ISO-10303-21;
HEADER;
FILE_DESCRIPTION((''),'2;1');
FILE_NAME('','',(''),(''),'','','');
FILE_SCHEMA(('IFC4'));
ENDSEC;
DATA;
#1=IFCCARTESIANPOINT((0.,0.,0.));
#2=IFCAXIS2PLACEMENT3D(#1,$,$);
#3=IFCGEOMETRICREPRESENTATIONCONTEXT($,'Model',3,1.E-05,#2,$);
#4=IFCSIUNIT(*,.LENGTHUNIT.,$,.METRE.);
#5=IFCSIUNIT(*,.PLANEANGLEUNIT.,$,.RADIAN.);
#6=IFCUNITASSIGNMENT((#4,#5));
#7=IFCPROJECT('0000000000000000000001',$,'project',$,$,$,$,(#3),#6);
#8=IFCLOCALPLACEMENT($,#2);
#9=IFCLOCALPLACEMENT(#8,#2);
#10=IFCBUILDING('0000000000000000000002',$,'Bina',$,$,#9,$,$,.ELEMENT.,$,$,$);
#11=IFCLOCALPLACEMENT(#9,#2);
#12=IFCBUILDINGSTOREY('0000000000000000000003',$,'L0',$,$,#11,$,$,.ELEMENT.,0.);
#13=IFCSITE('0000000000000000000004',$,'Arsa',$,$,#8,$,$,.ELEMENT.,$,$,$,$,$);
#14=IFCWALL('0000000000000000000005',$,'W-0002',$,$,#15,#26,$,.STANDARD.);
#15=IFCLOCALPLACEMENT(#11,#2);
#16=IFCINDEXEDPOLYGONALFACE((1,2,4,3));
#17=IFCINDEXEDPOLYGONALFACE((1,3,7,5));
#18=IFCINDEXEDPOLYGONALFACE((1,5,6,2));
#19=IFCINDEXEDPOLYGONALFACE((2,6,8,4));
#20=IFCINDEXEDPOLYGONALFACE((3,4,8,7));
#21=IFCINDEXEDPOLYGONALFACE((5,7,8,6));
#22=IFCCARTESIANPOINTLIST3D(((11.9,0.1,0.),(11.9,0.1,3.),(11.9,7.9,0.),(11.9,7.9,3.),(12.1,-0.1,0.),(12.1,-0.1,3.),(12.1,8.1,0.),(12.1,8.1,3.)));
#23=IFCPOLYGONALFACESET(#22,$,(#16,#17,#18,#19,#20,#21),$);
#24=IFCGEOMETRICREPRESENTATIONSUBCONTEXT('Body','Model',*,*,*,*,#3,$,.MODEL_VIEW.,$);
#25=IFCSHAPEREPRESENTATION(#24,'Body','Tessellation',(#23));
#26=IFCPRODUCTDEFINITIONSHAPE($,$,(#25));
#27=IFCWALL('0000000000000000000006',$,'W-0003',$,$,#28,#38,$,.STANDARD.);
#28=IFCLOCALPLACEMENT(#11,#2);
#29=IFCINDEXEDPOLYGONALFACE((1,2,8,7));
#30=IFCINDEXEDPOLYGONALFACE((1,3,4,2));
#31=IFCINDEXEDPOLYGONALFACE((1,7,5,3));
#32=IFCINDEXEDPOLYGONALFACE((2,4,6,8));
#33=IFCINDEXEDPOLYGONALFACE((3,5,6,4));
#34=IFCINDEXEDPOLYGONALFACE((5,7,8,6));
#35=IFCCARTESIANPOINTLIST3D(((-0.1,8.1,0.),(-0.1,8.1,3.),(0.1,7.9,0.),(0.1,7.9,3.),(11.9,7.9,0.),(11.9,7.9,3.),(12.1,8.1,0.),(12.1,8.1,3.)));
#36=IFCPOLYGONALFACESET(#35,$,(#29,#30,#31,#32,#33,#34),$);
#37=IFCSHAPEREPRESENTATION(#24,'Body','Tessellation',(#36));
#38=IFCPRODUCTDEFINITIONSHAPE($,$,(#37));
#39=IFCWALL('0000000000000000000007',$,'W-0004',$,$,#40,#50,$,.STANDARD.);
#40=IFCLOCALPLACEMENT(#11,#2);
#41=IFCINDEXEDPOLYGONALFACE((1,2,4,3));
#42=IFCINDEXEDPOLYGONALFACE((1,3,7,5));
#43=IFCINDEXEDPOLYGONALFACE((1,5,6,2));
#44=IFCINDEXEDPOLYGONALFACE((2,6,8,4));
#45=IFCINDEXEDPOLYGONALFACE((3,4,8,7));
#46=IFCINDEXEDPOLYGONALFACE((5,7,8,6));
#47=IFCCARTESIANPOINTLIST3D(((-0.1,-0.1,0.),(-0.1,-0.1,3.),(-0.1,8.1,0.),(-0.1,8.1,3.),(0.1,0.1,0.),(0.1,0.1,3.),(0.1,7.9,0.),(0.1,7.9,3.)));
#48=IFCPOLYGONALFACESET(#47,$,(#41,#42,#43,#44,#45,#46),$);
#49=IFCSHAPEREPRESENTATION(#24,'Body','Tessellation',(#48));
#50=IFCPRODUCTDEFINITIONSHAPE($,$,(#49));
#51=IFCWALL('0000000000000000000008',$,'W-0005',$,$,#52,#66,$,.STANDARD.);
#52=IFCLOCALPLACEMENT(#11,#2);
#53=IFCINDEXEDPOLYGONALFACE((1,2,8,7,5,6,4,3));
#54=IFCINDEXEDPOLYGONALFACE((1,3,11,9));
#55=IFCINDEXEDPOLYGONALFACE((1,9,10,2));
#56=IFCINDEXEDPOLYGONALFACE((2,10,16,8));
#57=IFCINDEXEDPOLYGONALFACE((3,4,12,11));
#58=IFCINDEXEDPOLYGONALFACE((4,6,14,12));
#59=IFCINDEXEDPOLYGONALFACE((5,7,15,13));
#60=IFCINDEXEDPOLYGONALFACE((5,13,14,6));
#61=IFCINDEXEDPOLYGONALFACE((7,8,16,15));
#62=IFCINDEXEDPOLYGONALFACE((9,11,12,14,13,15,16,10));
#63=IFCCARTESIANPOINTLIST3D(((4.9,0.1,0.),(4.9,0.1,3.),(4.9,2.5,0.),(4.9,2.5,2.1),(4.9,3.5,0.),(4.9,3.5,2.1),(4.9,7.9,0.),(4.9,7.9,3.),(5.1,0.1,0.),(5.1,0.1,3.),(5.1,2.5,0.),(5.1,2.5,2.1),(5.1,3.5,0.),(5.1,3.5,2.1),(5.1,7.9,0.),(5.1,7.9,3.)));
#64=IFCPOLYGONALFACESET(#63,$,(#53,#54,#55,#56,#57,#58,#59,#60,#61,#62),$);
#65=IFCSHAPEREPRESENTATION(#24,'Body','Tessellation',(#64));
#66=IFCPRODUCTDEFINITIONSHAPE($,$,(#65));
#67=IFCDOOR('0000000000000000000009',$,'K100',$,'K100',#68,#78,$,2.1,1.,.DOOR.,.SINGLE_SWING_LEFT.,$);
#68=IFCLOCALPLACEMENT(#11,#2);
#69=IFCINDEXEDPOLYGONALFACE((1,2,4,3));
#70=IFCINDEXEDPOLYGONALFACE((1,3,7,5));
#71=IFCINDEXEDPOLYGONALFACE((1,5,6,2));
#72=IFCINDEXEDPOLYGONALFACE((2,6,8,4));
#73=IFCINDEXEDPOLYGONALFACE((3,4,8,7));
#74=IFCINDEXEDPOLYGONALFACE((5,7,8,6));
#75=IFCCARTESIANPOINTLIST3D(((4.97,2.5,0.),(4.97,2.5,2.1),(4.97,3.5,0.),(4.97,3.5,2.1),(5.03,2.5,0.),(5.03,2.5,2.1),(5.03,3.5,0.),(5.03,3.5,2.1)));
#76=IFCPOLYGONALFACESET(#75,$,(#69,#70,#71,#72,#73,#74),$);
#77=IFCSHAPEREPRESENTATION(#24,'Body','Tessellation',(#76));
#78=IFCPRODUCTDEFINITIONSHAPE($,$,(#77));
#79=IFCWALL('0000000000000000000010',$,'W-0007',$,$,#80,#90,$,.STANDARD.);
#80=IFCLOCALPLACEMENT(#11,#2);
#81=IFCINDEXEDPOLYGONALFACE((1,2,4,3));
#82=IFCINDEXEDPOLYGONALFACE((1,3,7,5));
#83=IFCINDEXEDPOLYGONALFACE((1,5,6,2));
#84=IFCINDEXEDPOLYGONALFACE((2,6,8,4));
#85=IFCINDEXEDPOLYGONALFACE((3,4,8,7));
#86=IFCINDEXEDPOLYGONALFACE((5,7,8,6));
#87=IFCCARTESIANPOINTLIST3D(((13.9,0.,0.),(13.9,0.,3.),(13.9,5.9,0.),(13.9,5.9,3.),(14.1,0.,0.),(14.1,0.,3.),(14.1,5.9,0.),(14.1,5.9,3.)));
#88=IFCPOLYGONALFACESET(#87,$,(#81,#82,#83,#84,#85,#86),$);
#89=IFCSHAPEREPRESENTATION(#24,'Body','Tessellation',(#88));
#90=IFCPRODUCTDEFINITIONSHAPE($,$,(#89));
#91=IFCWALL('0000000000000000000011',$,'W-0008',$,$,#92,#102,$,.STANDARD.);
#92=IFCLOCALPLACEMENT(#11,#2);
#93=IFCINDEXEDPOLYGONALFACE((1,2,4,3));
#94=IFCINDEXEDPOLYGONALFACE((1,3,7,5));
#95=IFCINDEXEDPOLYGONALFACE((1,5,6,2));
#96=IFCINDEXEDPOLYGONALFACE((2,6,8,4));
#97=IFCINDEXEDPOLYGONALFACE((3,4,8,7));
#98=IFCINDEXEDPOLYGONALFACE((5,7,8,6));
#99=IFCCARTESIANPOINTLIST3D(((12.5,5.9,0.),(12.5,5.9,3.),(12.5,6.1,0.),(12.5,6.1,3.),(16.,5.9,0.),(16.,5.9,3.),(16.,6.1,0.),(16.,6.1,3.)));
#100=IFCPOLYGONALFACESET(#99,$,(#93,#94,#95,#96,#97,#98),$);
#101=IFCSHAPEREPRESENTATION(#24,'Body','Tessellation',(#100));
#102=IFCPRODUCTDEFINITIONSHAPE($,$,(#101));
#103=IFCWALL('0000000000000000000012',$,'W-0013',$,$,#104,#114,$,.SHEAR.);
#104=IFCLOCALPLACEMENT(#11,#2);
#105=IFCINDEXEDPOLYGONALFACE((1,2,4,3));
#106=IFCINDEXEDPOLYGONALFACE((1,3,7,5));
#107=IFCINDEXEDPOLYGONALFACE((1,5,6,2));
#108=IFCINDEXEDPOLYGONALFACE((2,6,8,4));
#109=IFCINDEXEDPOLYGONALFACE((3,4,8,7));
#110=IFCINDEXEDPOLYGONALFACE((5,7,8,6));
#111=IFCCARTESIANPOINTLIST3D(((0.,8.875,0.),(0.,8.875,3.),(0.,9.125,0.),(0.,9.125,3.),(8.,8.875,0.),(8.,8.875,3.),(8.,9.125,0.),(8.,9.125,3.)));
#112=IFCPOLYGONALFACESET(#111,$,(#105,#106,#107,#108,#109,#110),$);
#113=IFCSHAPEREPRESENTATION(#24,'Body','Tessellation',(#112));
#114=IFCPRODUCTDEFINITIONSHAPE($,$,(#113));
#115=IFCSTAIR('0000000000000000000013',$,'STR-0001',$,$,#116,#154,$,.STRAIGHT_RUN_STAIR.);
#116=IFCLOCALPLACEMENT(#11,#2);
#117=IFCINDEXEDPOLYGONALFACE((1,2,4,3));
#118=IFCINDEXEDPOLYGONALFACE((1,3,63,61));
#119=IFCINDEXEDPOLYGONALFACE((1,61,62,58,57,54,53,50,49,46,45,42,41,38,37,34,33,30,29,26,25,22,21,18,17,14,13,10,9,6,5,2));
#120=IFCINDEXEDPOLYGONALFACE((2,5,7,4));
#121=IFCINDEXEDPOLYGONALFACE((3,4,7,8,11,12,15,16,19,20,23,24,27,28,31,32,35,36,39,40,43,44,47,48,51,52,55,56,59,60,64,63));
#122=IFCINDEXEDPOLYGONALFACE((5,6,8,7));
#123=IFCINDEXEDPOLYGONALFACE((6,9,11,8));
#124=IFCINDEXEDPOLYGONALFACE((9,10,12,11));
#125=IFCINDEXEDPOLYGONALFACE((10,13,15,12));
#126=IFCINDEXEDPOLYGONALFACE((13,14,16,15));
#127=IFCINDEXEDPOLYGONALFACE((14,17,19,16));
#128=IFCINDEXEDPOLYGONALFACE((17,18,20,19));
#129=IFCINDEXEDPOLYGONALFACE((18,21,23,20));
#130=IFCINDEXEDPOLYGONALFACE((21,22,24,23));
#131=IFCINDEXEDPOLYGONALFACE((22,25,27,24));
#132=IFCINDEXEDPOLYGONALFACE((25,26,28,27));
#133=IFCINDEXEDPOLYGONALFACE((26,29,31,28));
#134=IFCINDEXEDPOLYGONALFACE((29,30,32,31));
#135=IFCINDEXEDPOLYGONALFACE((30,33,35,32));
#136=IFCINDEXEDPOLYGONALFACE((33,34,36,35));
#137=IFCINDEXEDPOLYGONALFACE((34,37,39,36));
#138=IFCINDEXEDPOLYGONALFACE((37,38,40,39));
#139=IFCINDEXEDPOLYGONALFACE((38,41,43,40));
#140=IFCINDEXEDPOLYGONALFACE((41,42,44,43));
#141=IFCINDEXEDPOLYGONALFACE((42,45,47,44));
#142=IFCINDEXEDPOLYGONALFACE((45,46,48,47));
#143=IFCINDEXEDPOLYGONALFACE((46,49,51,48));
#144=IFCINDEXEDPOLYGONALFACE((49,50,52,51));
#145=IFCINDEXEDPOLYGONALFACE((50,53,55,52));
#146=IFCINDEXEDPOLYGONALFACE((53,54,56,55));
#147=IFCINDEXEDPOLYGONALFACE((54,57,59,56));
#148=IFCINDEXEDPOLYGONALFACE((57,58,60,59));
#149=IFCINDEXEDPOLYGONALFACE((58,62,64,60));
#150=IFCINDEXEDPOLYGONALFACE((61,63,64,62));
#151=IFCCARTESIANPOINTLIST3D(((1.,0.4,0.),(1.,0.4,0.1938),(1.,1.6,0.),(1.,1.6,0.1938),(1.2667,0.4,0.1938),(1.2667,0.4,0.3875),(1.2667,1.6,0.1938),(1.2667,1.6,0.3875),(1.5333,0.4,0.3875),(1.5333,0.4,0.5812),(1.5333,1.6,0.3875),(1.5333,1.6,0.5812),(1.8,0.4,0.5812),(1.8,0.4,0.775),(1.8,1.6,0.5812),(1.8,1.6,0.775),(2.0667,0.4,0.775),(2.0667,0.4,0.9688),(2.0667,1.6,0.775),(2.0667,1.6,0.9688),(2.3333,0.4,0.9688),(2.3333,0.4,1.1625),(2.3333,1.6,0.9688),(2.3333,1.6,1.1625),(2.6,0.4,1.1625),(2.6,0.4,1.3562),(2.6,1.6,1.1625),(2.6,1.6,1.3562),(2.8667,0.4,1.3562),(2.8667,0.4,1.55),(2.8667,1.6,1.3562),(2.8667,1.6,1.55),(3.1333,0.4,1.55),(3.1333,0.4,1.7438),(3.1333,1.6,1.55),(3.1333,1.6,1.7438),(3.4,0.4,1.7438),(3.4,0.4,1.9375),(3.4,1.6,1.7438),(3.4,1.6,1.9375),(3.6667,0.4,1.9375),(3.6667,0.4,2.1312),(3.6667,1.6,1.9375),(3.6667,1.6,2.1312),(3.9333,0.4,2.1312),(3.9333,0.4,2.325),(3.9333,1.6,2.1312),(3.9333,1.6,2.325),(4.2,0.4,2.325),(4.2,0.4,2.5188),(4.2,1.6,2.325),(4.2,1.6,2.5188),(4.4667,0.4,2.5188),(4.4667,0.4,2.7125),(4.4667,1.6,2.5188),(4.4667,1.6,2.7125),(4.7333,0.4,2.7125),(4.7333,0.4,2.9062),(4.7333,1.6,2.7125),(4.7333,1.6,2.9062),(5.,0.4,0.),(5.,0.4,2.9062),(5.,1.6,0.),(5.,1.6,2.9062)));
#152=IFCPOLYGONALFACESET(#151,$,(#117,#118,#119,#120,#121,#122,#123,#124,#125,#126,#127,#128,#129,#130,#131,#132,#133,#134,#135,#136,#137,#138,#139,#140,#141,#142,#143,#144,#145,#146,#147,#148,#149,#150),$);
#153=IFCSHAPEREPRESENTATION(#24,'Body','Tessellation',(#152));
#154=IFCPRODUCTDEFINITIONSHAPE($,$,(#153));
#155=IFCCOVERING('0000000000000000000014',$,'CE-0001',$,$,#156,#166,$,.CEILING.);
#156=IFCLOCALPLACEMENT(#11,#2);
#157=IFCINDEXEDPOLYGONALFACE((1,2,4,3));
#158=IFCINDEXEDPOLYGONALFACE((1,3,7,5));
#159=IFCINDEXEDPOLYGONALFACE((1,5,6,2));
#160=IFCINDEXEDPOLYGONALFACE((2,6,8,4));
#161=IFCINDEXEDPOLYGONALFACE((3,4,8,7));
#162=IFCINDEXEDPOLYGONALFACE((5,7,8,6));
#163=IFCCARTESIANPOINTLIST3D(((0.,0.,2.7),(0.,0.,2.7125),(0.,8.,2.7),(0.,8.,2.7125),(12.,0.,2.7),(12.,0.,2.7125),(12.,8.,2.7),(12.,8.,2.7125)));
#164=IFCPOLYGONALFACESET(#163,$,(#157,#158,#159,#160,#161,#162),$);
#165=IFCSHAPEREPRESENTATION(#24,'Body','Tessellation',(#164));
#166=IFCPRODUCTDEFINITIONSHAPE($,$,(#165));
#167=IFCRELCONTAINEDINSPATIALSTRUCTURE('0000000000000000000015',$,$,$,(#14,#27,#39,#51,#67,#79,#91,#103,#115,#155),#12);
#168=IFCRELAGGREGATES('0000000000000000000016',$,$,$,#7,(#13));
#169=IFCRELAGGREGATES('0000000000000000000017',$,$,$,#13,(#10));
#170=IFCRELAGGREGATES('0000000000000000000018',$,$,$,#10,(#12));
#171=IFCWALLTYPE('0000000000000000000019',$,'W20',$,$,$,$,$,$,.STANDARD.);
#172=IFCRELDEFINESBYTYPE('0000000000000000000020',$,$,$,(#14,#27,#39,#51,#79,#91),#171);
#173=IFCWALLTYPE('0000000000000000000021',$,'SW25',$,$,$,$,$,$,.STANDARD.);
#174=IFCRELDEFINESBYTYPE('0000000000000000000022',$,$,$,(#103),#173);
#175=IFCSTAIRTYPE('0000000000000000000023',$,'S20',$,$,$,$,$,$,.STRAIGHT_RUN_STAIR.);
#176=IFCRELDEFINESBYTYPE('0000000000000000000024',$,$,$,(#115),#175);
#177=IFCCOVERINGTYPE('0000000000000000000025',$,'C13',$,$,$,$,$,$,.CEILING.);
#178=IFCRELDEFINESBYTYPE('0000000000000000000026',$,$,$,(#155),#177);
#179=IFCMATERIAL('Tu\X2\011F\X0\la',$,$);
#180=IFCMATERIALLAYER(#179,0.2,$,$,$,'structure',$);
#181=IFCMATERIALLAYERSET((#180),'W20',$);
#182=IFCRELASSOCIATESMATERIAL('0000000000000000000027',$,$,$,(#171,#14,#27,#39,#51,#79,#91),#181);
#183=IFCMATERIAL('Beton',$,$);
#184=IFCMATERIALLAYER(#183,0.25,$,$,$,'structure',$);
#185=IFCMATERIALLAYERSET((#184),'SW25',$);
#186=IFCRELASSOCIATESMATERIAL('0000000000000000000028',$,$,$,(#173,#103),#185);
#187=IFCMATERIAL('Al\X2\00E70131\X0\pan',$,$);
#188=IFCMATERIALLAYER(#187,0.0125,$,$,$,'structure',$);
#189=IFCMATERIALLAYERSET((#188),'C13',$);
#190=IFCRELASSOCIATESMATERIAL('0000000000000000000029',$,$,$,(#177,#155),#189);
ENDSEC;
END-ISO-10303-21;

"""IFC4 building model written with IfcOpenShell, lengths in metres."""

from ifc_helpers import new_model, si_unit, frame, origin, origin_2d, place, context, subcontext, project, spatial, polyline, rectangle, outline, extrude, material, layer, layer_set, layer_usage, type_object, element, fill, save


model = new_model("IFC4")

# Units and contexts
model_context = context("Model", 3, precision=1e-05, world=origin())
body_context = subcontext(model_context, "Body", "Model", "MODEL_VIEW")
ifc_project = project(units=[si_unit("LENGTHUNIT", "METRE"), si_unit("PLANEANGLEUNIT", "RADIAN")], contexts=[model_context])

# Site, building, storey
site_placement = place(None, origin())
site = spatial("IfcSite", under=ifc_project, at=site_placement, Name="Arsa", CompositionType="ELEMENT")
building_placement = place(site_placement, origin())
building = spatial("IfcBuilding", under=site, at=building_placement, Name="Bina", CompositionType="ELEMENT")
storey_placement = place(building_placement, origin())
storey = spatial("IfcBuildingStorey", under=building, at=storey_placement, Name="L0", CompositionType="ELEMENT", Elevation=0.0)

# Shared definitions
ifc_material_1 = material(Name="Beton")

# Shared definitions
ifc_material_2 = material(Name="Tuğla")
ifc_layer_1 = layer(ifc_material_2, 0.2, Category="structure")
ifc_layer_set_1 = layer_set([ifc_layer_1], Name="W20")
wall_type_1 = type_object("IfcWallType", Name="W20", PredefinedType="STANDARD", material=ifc_layer_set_1)

# Walls
ifc_layer_usage_1 = layer_usage(ifc_layer_set_1, "AXIS2", "POSITIVE", -0.1)
wall_1_placement = place(storey_placement, frame((12.0, 0.0, 0.0), z_axis=(0.0, 0.0, 1.0), x_axis=(0.0, 1.0, 0.0)))
element("IfcWall", 1, at=wall_1_placement, inside=storey, type_object=wall_type_1, material=ifc_layer_usage_1, Name="W-0002", PredefinedType="STANDARD", context=body_context, shape_type="SweptSolid", body=[
    extrude(outline(polyline([(0.1, 0.1), (7.9, 0.1), (8.1, -0.1), (-0.1, -0.1), (0.1, 0.1)])), origin(), (0.0, 0.0, 1.0), 3.0),
])
ifc_layer_usage_2 = layer_usage(ifc_layer_set_1, "AXIS2", "POSITIVE", -0.1)
wall_2_placement = place(storey_placement, frame((12.0, 8.0, 0.0), z_axis=(0.0, 0.0, 1.0), x_axis=(-1.0, 0.0, 0.0)))
element("IfcWall", 2, at=wall_2_placement, inside=storey, type_object=wall_type_1, material=ifc_layer_usage_2, Name="W-0003", PredefinedType="STANDARD", context=body_context, shape_type="SweptSolid", body=[
    extrude(outline(polyline([(0.1, 0.1), (11.9, 0.1), (12.1, -0.1), (-0.1, -0.1), (0.1, 0.1)])), origin(), (0.0, 0.0, 1.0), 3.0),
])
ifc_layer_usage_3 = layer_usage(ifc_layer_set_1, "AXIS2", "POSITIVE", -0.1)
wall_3_placement = place(storey_placement, frame((0.0, 8.0, 0.0), z_axis=(0.0, 0.0, 1.0), x_axis=(0.0, -1.0, 0.0)))
element("IfcWall", 3, at=wall_3_placement, inside=storey, type_object=wall_type_1, material=ifc_layer_usage_3, Name="W-0004", PredefinedType="STANDARD", context=body_context, shape_type="SweptSolid", body=[
    extrude(outline(polyline([(0.1, 0.1), (7.9, 0.1), (8.1, -0.1), (-0.1, -0.1), (0.1, 0.1)])), origin(), (0.0, 0.0, 1.0), 3.0),
])

# Wall, opening, door
ifc_layer_usage_4 = layer_usage(ifc_layer_set_1, "AXIS2", "POSITIVE", -0.1)
wall_4_placement = place(storey_placement, frame((5.0, 0.0, 0.0), z_axis=(0.0, 0.0, 1.0), x_axis=(0.0, 1.0, 0.0)))
wall_4 = element("IfcWall", 4, at=wall_4_placement, inside=storey, type_object=wall_type_1, material=ifc_layer_usage_4, Name="W-0005", PredefinedType="STANDARD", context=body_context, shape_type="SweptSolid", body=[
    extrude(outline(polyline([(0.1, 0.1), (7.9, 0.1), (7.9, -0.1), (0.1, -0.1), (0.1, 0.1)])), origin(), (0.0, 0.0, 1.0), 3.0),
])
opening_1_placement = place(wall_4_placement, frame((3.0, 0.0, 0.0)))
opening_1 = element("IfcOpeningElement", 5, at=opening_1_placement, cuts=wall_4, PredefinedType="OPENING", context=body_context, shape_type="SweptSolid", body=[
    extrude(rectangle(XDim=1.0, YDim=0.3, at=origin_2d()), origin(), (0.0, 0.0, 1.0), 2.1),
])
door_placement = place(opening_1_placement, origin())
door = element("IfcDoor", 6, at=door_placement, inside=storey, Name="K100", ObjectType="K100", OperationType="SINGLE_SWING_LEFT", OverallHeight=2.1, OverallWidth=1.0, PredefinedType="DOOR", context=body_context, shape_type="SweptSolid", body=[
    extrude(rectangle(XDim=1.0, YDim=0.06, at=origin_2d()), origin(), (0.0, 0.0, 1.0), 2.1),
])
fill(opening_1, door)

# Walls
ifc_layer_usage_5 = layer_usage(ifc_layer_set_1, "AXIS2", "POSITIVE", -0.1)
wall_5_placement = place(storey_placement, frame((14.0, 0.0, 0.0), z_axis=(0.0, 0.0, 1.0), x_axis=(0.0, 1.0, 0.0)))
element("IfcWall", 7, at=wall_5_placement, inside=storey, type_object=wall_type_1, material=ifc_layer_usage_5, Name="W-0007", PredefinedType="STANDARD", context=body_context, shape_type="SweptSolid", body=[
    extrude(outline(polyline([(0.0, 0.1), (5.9, 0.1), (5.9, -0.1), (0.0, -0.1), (0.0, 0.1)])), origin(), (0.0, 0.0, 1.0), 3.0),
])
ifc_layer_usage_6 = layer_usage(ifc_layer_set_1, "AXIS2", "POSITIVE", -0.1)
wall_6_placement = place(storey_placement, frame((12.5, 6.0, 0.0), z_axis=(0.0, 0.0, 1.0), x_axis=(1.0, 0.0, 0.0)))
element("IfcWall", 8, at=wall_6_placement, inside=storey, type_object=wall_type_1, material=ifc_layer_usage_6, Name="W-0008", PredefinedType="STANDARD", context=body_context, shape_type="SweptSolid", body=[
    extrude(outline(polyline([(0.0, 0.1), (3.5, 0.1), (3.5, -0.1), (0.0, -0.1), (0.0, 0.1)])), origin(), (0.0, 0.0, 1.0), 3.0),
])
ifc_layer_2 = layer(ifc_material_1, 0.25, Category="structure")
ifc_layer_set_2 = layer_set([ifc_layer_2], Name="SW25")
ifc_layer_usage_7 = layer_usage(ifc_layer_set_2, "AXIS2", "POSITIVE", -0.125)
wall_type_2 = type_object("IfcWallType", Name="SW25", PredefinedType="STANDARD", material=ifc_layer_set_2)
wall_7_placement = place(storey_placement, frame((0.0, 9.0, 0.0), z_axis=(0.0, 0.0, 1.0), x_axis=(1.0, 0.0, 0.0)))
element("IfcWall", 9, at=wall_7_placement, inside=storey, type_object=wall_type_2, material=ifc_layer_usage_7, Name="W-0013", PredefinedType="SHEAR", context=body_context, shape_type="SweptSolid", body=[
    extrude(outline(polyline([(0.0, 0.125), (8.0, 0.125), (8.0, -0.125), (0.0, -0.125), (0.0, 0.125)])), origin(), (0.0, 0.0, 1.0), 3.0),
])

# Stair
stair_type = type_object("IfcStairType", Name="S20", PredefinedType="STRAIGHT_RUN_STAIR")
stair_placement = place(storey_placement, origin())
element("IfcStair", 10, at=stair_placement, inside=storey, type_object=stair_type, Name="STR-0001", PredefinedType="STRAIGHT_RUN_STAIR", context=body_context, shape_type="SweptSolid", body=[
    extrude(outline(polyline([(0.0, 0.0), (0.0, 0.1938), (0.2667, 0.1938), (0.2667, 0.3875), (0.5333, 0.3875), (0.5333, 0.5813), (0.8, 0.5813), (0.8, 0.775), (1.0667, 0.775), (1.0667, 0.9688), (1.3333, 0.9688), (1.3333, 1.1625), (1.6, 1.1625), (1.6, 1.3562), (1.8667, 1.3562), (1.8667, 1.55), (2.1333, 1.55), (2.1333, 1.7437), (2.4, 1.7437), (2.4, 1.9375), (2.6667, 1.9375), (2.6667, 2.1313), (2.9333, 2.1313), (2.9333, 2.325), (3.2, 2.325), (3.2, 2.5187), (3.4667, 2.5187), (3.4667, 2.7125), (3.7333, 2.7125), (3.7333, 2.9062), (4.0, 2.9062), (4.0, 0.0), (0.0, 0.0)])), frame((1.0, 1.6, 0.0), z_axis=(0.0, -1.0, 0.0), x_axis=(1.0, 0.0, 0.0)), (0.0, 0.0, 1.0), 1.2),
])

# Covering
ifc_material_3 = material(Name="Alçıpan")
ifc_layer_3 = layer(ifc_material_3, 0.0125, Category="structure")
ifc_layer_set_3 = layer_set([ifc_layer_3], Name="C13")
ifc_layer_usage_8 = layer_usage(ifc_layer_set_3, "AXIS3", "POSITIVE", 2.7)
covering_type = type_object("IfcCoveringType", Name="C13", PredefinedType="CEILING", material=ifc_layer_set_3)
covering_placement = place(storey_placement, origin())
element("IfcCovering", 11, at=covering_placement, inside=storey, type_object=covering_type, material=ifc_layer_usage_8, Name="CE-0001", PredefinedType="CEILING", context=body_context, shape_type="SweptSolid", body=[
    extrude(outline(polyline([(0.0, 0.0), (12.0, 0.0), (12.0, 8.0), (0.0, 8.0), (0.0, 0.0)])), frame((0.0, 0.0, 2.7)), (0.0, 0.0, 1.0), 0.0125),
])

save(model, "model.ifc")
